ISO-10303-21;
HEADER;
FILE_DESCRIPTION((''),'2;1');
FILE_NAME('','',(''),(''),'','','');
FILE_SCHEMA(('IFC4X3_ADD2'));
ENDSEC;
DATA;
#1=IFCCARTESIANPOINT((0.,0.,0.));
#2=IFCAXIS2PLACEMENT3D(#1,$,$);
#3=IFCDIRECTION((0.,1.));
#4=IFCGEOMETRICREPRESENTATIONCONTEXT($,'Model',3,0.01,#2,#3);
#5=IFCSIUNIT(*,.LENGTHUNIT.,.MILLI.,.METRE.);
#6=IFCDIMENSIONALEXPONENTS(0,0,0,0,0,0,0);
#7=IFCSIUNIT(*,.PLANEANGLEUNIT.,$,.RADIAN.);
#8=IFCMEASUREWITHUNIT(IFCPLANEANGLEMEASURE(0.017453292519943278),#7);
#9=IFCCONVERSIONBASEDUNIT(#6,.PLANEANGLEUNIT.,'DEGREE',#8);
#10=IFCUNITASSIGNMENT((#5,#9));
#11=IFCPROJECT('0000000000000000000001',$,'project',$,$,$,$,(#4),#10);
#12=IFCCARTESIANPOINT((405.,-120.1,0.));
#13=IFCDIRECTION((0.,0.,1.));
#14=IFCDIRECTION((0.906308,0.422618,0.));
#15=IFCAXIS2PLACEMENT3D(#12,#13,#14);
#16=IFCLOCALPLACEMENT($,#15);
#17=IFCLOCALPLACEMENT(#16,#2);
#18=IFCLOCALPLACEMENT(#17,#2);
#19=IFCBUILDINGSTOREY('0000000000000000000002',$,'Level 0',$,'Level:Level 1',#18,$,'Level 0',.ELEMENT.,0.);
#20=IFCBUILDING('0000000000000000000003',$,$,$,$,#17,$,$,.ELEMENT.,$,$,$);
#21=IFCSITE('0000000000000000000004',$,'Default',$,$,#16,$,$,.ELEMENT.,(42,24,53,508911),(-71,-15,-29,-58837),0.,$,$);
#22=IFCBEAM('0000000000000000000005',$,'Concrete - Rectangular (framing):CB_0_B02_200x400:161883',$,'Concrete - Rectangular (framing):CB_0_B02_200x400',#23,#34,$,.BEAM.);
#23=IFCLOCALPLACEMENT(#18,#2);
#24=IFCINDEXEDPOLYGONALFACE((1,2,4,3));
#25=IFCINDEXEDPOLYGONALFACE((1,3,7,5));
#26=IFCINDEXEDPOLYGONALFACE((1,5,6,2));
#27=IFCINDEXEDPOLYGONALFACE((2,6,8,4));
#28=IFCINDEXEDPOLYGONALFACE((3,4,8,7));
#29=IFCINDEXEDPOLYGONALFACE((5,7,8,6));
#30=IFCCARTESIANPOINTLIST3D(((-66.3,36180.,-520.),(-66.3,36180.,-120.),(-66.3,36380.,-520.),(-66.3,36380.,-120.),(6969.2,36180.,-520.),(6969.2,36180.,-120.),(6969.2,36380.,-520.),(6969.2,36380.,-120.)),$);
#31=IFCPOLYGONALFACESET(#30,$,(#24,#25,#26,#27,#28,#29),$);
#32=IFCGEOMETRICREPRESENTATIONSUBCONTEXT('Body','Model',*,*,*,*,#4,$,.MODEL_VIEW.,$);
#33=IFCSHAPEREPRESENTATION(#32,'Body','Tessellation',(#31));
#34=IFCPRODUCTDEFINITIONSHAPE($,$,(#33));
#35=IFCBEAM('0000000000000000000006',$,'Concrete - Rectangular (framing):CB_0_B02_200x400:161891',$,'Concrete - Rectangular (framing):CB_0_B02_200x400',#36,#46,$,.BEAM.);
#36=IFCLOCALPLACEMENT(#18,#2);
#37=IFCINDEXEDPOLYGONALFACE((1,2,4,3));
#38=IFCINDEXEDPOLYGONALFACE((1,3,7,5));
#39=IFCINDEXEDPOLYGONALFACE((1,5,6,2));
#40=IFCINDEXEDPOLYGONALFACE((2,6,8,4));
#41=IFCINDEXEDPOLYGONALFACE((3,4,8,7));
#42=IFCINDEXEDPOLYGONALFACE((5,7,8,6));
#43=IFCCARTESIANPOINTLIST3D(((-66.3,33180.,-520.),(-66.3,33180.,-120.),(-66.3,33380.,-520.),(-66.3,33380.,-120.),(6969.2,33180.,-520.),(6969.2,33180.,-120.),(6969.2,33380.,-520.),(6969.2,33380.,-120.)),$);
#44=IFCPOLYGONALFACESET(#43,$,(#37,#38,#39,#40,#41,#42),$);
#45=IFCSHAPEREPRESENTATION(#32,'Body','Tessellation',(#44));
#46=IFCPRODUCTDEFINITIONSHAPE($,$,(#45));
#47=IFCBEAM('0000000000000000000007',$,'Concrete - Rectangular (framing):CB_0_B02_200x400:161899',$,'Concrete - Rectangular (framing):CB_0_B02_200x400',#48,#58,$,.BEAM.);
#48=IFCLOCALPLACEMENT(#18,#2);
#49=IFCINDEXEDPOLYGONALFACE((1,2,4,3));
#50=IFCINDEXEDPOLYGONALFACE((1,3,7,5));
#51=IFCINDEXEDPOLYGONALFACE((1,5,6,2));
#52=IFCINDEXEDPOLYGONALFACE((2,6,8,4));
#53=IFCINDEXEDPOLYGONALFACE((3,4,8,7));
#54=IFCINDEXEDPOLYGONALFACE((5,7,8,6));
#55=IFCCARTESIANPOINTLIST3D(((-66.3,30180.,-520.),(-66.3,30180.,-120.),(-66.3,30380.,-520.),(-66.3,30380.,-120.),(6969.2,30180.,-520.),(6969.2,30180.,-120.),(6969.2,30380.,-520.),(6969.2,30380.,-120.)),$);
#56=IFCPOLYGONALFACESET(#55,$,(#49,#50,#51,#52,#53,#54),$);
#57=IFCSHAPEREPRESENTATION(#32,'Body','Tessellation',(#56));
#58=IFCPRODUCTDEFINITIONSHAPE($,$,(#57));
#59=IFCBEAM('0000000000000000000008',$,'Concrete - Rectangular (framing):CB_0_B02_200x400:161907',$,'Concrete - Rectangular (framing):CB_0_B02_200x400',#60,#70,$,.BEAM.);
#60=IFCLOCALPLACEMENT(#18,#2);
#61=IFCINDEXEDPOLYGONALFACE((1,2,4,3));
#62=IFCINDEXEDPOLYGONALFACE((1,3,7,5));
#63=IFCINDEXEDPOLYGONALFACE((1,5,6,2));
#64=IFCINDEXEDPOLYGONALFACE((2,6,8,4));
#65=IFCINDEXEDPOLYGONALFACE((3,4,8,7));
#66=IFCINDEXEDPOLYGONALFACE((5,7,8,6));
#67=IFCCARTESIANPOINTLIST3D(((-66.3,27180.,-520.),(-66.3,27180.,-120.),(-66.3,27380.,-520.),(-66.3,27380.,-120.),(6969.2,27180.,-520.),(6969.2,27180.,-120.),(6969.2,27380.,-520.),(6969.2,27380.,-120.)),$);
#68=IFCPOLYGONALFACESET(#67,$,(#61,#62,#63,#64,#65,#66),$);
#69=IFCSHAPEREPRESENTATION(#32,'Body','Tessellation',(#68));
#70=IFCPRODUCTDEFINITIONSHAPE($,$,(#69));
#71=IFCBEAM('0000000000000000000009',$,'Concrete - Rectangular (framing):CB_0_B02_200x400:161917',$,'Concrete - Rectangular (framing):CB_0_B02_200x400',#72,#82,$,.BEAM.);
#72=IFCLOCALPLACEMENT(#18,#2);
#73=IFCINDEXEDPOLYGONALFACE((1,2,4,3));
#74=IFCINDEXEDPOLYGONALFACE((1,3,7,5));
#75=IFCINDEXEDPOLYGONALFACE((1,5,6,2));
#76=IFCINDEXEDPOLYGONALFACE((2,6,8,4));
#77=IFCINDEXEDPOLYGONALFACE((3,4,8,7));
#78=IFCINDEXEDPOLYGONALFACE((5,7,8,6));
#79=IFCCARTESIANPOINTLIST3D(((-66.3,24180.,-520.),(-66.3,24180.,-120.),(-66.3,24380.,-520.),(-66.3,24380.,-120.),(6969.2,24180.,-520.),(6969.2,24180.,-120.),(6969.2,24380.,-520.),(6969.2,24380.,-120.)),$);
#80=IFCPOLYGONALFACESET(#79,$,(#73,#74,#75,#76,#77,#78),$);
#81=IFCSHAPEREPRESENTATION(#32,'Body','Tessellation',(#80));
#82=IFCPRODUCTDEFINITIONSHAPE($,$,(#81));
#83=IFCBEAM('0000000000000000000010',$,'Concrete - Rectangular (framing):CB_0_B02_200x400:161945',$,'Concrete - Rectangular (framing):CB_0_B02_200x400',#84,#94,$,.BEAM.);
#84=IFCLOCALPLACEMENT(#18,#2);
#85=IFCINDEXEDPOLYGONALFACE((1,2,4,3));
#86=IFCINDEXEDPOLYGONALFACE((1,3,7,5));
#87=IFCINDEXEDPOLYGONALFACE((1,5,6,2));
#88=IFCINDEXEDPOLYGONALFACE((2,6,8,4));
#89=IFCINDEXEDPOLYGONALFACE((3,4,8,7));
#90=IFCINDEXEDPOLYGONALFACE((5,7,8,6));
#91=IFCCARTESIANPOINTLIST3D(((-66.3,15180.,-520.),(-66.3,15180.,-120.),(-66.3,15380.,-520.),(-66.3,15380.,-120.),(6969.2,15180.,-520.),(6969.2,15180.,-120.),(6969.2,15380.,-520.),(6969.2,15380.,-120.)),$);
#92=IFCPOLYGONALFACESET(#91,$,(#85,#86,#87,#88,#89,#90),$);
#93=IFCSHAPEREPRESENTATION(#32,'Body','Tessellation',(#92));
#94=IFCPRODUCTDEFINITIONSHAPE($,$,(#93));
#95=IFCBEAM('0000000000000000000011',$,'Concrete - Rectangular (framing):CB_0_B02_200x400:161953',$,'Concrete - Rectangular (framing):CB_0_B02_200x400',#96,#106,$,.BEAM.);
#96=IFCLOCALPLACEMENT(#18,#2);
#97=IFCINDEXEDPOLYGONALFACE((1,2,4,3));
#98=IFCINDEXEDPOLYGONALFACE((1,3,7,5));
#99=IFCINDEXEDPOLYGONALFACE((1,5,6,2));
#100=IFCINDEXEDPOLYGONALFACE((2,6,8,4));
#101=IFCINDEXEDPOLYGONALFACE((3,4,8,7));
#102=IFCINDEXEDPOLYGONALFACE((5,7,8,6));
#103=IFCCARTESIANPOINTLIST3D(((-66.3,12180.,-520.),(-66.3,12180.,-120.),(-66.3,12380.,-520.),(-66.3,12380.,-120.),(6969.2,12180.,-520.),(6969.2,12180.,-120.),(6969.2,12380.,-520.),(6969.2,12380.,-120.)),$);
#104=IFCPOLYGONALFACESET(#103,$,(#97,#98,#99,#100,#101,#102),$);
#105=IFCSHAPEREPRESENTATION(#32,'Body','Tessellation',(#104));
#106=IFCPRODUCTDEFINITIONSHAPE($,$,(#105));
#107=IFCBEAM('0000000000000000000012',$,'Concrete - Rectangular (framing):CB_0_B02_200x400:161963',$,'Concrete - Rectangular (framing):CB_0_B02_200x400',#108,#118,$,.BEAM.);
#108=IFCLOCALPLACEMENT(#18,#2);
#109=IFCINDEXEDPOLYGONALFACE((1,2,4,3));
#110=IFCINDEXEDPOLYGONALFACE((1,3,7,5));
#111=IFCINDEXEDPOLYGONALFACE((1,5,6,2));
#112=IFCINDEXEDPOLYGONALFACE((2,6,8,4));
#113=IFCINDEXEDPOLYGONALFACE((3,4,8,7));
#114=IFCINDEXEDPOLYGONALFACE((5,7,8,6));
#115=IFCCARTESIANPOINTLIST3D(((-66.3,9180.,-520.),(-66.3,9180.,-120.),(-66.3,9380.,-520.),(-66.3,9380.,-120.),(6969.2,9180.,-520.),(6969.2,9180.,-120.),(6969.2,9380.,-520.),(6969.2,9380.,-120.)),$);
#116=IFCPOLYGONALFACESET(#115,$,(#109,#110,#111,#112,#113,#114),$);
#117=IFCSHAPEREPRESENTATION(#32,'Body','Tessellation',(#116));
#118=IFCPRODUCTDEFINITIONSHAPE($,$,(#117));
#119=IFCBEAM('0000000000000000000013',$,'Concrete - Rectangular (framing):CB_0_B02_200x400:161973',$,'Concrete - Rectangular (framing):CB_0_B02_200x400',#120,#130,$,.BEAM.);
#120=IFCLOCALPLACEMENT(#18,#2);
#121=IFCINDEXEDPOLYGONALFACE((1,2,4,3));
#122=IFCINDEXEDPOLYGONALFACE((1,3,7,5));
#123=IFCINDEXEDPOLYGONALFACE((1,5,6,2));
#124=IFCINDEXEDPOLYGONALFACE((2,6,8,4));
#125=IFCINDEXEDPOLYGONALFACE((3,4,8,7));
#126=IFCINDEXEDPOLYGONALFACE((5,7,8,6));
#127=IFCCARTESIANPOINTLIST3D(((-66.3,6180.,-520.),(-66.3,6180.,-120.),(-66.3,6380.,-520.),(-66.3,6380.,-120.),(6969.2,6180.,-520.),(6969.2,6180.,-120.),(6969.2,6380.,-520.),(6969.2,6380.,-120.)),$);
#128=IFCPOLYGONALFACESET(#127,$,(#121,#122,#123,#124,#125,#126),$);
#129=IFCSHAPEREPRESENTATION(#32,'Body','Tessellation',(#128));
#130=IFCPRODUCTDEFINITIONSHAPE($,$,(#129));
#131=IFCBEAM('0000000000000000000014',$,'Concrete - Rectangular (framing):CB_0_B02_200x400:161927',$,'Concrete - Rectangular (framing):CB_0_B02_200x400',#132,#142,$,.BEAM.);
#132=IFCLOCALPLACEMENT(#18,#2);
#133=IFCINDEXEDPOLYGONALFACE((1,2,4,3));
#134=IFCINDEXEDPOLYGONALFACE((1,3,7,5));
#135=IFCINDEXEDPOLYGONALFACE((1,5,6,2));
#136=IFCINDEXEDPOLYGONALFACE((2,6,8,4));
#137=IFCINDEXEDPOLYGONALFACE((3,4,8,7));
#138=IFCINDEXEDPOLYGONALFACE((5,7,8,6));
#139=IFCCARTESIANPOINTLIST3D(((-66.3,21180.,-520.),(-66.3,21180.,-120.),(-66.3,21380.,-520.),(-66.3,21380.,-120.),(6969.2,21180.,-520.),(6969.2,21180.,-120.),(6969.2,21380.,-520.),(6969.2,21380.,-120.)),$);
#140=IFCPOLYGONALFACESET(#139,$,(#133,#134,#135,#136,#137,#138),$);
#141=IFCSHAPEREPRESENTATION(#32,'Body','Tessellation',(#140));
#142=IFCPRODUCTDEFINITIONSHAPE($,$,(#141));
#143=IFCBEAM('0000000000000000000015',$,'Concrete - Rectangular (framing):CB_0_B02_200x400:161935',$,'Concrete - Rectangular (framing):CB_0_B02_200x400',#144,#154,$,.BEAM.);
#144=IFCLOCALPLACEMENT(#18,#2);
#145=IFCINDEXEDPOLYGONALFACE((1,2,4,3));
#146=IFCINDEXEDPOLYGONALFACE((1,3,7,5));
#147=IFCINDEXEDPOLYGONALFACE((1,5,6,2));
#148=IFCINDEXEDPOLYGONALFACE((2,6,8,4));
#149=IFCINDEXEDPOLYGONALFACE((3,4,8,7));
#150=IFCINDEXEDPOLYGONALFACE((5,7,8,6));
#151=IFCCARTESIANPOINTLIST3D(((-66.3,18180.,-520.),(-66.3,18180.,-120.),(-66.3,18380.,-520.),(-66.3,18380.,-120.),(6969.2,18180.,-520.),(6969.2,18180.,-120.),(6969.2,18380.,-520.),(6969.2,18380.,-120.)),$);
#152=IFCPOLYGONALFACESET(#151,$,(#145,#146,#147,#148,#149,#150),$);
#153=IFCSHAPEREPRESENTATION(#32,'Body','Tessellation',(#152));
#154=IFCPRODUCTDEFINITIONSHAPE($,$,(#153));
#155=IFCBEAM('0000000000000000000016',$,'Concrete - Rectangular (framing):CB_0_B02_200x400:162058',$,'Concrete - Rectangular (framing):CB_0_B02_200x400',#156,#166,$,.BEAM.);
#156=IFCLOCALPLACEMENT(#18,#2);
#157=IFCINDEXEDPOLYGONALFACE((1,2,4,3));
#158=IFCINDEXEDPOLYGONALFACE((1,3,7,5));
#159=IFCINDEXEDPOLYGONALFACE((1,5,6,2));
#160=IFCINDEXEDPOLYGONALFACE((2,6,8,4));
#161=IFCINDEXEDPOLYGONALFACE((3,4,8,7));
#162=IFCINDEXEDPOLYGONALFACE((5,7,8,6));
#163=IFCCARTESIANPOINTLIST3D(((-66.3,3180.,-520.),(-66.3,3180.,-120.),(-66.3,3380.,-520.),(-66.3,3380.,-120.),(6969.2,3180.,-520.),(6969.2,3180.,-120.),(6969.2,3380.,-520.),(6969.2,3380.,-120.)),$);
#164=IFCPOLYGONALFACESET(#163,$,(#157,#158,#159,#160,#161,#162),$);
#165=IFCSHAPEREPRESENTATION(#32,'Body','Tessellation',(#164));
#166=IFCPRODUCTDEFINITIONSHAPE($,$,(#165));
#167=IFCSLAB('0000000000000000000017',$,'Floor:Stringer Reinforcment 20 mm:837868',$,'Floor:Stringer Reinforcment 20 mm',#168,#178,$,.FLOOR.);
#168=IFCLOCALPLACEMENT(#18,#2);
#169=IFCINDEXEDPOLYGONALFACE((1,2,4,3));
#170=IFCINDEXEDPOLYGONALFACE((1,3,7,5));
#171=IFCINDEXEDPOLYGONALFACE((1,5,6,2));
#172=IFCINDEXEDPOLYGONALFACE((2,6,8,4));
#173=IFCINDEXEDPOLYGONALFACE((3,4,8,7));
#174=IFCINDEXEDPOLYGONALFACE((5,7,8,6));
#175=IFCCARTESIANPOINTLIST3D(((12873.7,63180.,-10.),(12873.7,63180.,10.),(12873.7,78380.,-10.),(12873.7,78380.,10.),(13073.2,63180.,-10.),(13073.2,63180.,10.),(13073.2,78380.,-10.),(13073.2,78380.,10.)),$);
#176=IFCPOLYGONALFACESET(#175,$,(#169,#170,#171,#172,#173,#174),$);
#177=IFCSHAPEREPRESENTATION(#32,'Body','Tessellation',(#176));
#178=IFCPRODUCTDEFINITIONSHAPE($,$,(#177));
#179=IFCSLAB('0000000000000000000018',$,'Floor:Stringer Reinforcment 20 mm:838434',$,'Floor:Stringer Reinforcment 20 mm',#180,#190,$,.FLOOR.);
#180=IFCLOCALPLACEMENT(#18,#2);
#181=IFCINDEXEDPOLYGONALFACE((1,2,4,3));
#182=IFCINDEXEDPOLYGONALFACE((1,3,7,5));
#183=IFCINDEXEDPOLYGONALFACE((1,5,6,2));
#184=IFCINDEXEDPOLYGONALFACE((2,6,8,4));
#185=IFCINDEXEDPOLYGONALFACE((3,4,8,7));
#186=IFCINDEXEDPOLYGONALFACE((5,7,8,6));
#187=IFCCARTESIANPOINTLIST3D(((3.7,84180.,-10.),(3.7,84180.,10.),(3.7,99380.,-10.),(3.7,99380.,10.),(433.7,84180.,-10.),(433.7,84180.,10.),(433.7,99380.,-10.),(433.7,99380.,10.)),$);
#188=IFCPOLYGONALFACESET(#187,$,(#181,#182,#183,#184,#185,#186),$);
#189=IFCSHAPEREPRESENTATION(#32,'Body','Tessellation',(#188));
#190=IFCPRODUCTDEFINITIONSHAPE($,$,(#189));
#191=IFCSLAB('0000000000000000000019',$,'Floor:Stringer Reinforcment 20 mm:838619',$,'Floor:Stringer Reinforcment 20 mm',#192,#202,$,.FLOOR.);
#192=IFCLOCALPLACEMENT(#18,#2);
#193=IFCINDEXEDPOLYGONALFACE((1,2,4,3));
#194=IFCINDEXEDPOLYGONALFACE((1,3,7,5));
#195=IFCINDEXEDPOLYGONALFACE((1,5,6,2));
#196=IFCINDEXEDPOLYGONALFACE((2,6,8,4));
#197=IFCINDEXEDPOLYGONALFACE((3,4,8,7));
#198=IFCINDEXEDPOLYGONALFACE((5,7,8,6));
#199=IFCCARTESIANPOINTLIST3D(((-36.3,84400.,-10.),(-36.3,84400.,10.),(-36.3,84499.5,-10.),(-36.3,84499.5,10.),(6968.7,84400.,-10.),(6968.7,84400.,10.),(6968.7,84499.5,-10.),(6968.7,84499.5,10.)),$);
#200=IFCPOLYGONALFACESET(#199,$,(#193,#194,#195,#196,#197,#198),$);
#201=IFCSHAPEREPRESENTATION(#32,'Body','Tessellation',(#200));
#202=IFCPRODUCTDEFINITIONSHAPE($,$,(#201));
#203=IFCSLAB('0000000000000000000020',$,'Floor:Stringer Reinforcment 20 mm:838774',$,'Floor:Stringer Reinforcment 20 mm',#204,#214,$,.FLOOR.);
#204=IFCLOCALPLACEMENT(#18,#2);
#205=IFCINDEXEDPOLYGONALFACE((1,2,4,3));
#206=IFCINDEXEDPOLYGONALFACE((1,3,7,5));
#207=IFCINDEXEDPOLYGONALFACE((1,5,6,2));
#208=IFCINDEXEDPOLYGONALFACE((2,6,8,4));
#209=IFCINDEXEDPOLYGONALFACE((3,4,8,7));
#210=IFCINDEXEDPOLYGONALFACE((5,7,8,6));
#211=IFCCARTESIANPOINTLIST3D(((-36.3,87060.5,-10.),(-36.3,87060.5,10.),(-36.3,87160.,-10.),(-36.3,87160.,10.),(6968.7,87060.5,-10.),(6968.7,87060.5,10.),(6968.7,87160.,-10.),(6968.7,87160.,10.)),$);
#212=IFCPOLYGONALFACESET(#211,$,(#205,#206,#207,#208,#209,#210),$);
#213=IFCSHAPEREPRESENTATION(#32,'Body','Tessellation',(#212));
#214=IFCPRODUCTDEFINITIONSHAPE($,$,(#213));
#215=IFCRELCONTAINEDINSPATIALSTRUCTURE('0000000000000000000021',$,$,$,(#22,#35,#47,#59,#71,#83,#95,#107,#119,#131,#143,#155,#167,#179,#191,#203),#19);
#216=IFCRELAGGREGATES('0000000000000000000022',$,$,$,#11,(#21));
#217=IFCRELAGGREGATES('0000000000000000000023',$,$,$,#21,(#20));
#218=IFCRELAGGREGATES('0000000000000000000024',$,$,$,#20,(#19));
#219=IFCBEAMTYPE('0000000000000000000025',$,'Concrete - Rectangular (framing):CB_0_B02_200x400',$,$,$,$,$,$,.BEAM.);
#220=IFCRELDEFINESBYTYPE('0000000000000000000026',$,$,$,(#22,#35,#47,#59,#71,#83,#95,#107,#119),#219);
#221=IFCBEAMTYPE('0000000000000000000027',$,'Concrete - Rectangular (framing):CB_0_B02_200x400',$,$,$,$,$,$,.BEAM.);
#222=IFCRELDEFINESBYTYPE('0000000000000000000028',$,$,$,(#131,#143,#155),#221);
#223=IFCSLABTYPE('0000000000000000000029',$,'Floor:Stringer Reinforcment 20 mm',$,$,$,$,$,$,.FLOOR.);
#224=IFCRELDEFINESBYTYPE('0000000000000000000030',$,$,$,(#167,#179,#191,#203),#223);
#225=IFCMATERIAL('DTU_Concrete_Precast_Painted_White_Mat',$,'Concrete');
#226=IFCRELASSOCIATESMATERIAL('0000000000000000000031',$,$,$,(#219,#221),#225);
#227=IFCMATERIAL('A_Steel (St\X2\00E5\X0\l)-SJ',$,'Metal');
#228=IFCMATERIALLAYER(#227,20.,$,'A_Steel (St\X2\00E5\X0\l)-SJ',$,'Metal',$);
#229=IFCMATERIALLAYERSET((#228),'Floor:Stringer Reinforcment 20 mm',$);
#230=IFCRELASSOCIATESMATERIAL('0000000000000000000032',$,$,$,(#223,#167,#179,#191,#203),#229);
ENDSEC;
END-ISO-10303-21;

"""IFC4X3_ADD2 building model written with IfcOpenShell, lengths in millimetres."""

from ifc_helpers import new_model, entity, si_unit, converted_unit, direction, frame, frame_2d, origin, origin_2d_with_axis, place, context, subcontext, project, spatial, rectangle, extrude, source, transform, mapped, material, layer, layer_set, layer_usage, material_profile, profile_set, type_object, type_shapes, element, save


model = new_model("IFC4X3_ADD2")

# Units and contexts
model_context = context("Model", 3, precision=0.01, world=origin(), true_north=direction((0.0, 1.0)))
body_context = subcontext(model_context, "Body", "Model", "MODEL_VIEW")
ifc_project = project(units=[si_unit("LENGTHUNIT", "METRE", prefix="MILLI"), converted_unit("PLANEANGLEUNIT", "DEGREE", entity("IfcPlaneAngleMeasure", 0.017453292519943278), si_unit("PLANEANGLEUNIT", "RADIAN"), dimensions=[0, 0, 0, 0, 0, 0, 0])], contexts=[model_context])

# Site, building, storey
site_placement = place(None, frame((405.0, -120.1, 0.0), z_axis=(0.0, 0.0, 1.0), x_axis=(0.906308, 0.422618, 0.0)))
site = spatial("IfcSite", under=ifc_project, at=site_placement, Name="Default", CompositionType="ELEMENT", RefLatitude=(42, 24, 53, 508911), RefLongitude=(-71, -15, -29, -58837), RefElevation=0.0)
building_placement = place(site_placement, origin())
building = spatial("IfcBuilding", under=site, at=building_placement, CompositionType="ELEMENT")
storey_placement = place(building_placement, origin())
storey = spatial("IfcBuildingStorey", under=building, at=storey_placement, Name="Level 0", ObjectType="Level:Level 1", LongName="Level 0", CompositionType="ELEMENT", Elevation=0.0)

# Beams
ifc_material_1 = material(Name="DTU_Concrete_Precast_Painted_White_Mat", Category="Concrete")
ifc_material_profile_1 = material_profile(ifc_material_1, rectangle(XDim=7035.5, YDim=200.0, at=frame_2d((0.0, 0.0), x_axis=(1.0, 0.0))), Name="CB_0_B02_200x400")
ifc_profile_set_1 = profile_set([ifc_material_profile_1], Name="CB_0_B02_200x400")
beam_type_1 = type_object("IfcBeamType", Name="Concrete - Rectangular (framing):CB_0_B02_200x400", PredefinedType="BEAM", material=ifc_profile_set_1)
shared_shape_1 = source(origin(), body_context, "Body", "SweptSolid", [
    extrude(rectangle(XDim=7035.5, YDim=200.0, at=frame_2d((0.0, 0.0), x_axis=(1.0, 0.0))), frame((-45.2, 0.0, -200.0), z_axis=(0.0, 0.0, 1.0), x_axis=(-1.0, 0.0, 0.0)), (0.0, 0.0, 1.0), 400.0),
])
type_shapes(beam_type_1, [shared_shape_1])
for number, where, z_axis, x_axis, name in (
    (1, (3406.2, 36280.0, -320.0), (0.0, 0.0, 1.0), (-1.0, 0.0, 0.0), "Concrete - Rectangular (framing):CB_0_B02_200x400:161883"),
    (2, (3406.2, 33280.0, -320.0), (0.0, 0.0, 1.0), (-1.0, 0.0, 0.0), "Concrete - Rectangular (framing):CB_0_B02_200x400:161891"),
    (3, (3406.2, 30280.0, -320.0), (0.0, 0.0, 1.0), (-1.0, 0.0, 0.0), "Concrete - Rectangular (framing):CB_0_B02_200x400:161899"),
    (4, (3406.2, 27280.0, -320.0), (0.0, 0.0, 1.0), (-1.0, 0.0, 0.0), "Concrete - Rectangular (framing):CB_0_B02_200x400:161907"),
    (5, (3406.2, 24280.0, -320.0), (0.0, 0.0, 1.0), (-1.0, 0.0, 0.0), "Concrete - Rectangular (framing):CB_0_B02_200x400:161917"),
    (6, (3406.2, 15280.0, -320.0), (0.0, 0.0, 1.0), (-1.0, 0.0, 0.0), "Concrete - Rectangular (framing):CB_0_B02_200x400:161945"),
    (7, (3406.2, 12280.0, -320.0), (0.0, 0.0, 1.0), (-1.0, 0.0, 0.0), "Concrete - Rectangular (framing):CB_0_B02_200x400:161953"),
    (8, (3406.2, 9280.0, -320.0), (0.0, 0.0, 1.0), (-1.0, 0.0, 0.0), "Concrete - Rectangular (framing):CB_0_B02_200x400:161963"),
    (9, (3406.2, 6280.0, -320.0), (0.0, 0.0, 1.0), (-1.0, 0.0, 0.0), "Concrete - Rectangular (framing):CB_0_B02_200x400:161973"),
):
    element("IfcBeam", number, at=place(storey_placement, frame(where, z_axis=z_axis, x_axis=x_axis)), inside=storey, type_object=beam_type_1, Name=name, ObjectType="Concrete - Rectangular (framing):CB_0_B02_200x400", PredefinedType="BEAM", context=body_context, shape_type="MappedRepresentation", body=[
        mapped(shared_shape_1, transform((0.0, 0.0, 0.0), scale=1.0)),
    ])
beam_type_2 = type_object("IfcBeamType", Name="Concrete - Rectangular (framing):CB_0_B02_200x400", PredefinedType="BEAM", material=ifc_profile_set_1)
shared_shape_2 = source(origin(), body_context, "Body", "SweptSolid", [
    extrude(rectangle(XDim=7035.5, YDim=200.0, at=origin_2d_with_axis()), frame((-45.3, 0.0, -200.0), z_axis=(0.0, 0.0, 1.0), x_axis=(-1.0, 0.0, 0.0)), (0.0, 0.0, 1.0), 400.0),
])
type_shapes(beam_type_2, [shared_shape_2])
for number, where, z_axis, x_axis, name in (
    (10, (3406.2, 21280.0, -320.0), (0.0, 0.0, 1.0), (-1.0, 0.0, 0.0), "Concrete - Rectangular (framing):CB_0_B02_200x400:161927"),
    (11, (3406.2, 18280.0, -320.0), (0.0, 0.0, 1.0), (-1.0, 0.0, 0.0), "Concrete - Rectangular (framing):CB_0_B02_200x400:161935"),
    (12, (3406.2, 3280.0, -320.0), (0.0, 0.0, 1.0), (-1.0, 0.0, 0.0), "Concrete - Rectangular (framing):CB_0_B02_200x400:162058"),
):
    element("IfcBeam", number, at=place(storey_placement, frame(where, z_axis=z_axis, x_axis=x_axis)), inside=storey, type_object=beam_type_2, Name=name, ObjectType="Concrete - Rectangular (framing):CB_0_B02_200x400", PredefinedType="BEAM", context=body_context, shape_type="MappedRepresentation", body=[
        mapped(shared_shape_2, transform((0.0, 0.0, 0.0), scale=1.0)),
    ])

# Slabs
ifc_material_2 = material(Name="A_Steel (Stål)-SJ", Category="Metal")
ifc_layer_1 = layer(ifc_material_2, 20.0, Name="A_Steel (Stål)-SJ", Category="Metal")
ifc_layer_set_1 = layer_set([ifc_layer_1], Name="Floor:Stringer Reinforcment 20 mm")
ifc_layer_usage_1 = layer_usage(ifc_layer_set_1, "AXIS3", "POSITIVE", 0.0)
slab_type_1 = type_object("IfcSlabType", Name="Floor:Stringer Reinforcment 20 mm", PredefinedType="FLOOR", material=ifc_layer_set_1)
slab_1_placement = place(storey_placement, origin())
element("IfcSlab", 13, at=slab_1_placement, inside=storey, type_object=slab_type_1, material=ifc_layer_usage_1, Name="Floor:Stringer Reinforcment 20 mm:837868", ObjectType="Floor:Stringer Reinforcment 20 mm", PredefinedType="FLOOR", context=body_context, shape_type="SweptSolid", body=[
    extrude(rectangle(XDim=15200.0, YDim=199.5, at=frame_2d((0.0, 0.0), x_axis=(1.0, 0.0))), frame((12973.5, 70780.0, 10.0), z_axis=(0.0, 0.0, -1.0), x_axis=(0.0, 1.0, 0.0)), (0.0, 0.0, 1.0), 20.0),
])
ifc_layer_usage_2 = layer_usage(ifc_layer_set_1, "AXIS3", "POSITIVE", 0.0)
slab_2_placement = place(storey_placement, origin())
element("IfcSlab", 14, at=slab_2_placement, inside=storey, type_object=slab_type_1, material=ifc_layer_usage_2, Name="Floor:Stringer Reinforcment 20 mm:838434", ObjectType="Floor:Stringer Reinforcment 20 mm", PredefinedType="FLOOR", context=body_context, shape_type="SweptSolid", body=[
    extrude(rectangle(XDim=15200.0, YDim=430.0, at=origin_2d_with_axis()), frame((218.7, 91780.0, 10.0), z_axis=(0.0, 0.0, -1.0), x_axis=(0.0, 1.0, 0.0)), (0.0, 0.0, 1.0), 20.0),
])
ifc_layer_usage_3 = layer_usage(ifc_layer_set_1, "AXIS3", "POSITIVE", 0.0)
slab_3_placement = place(storey_placement, origin())
element("IfcSlab", 15, at=slab_3_placement, inside=storey, type_object=slab_type_1, material=ifc_layer_usage_3, Name="Floor:Stringer Reinforcment 20 mm:838619", ObjectType="Floor:Stringer Reinforcment 20 mm", PredefinedType="FLOOR", context=body_context, shape_type="SweptSolid", body=[
    extrude(rectangle(XDim=99.5, YDim=7005.0, at=origin_2d_with_axis()), frame((3466.2, 84449.8, 10.0), z_axis=(0.0, 0.0, -1.0), x_axis=(0.0, 1.0, 0.0)), (0.0, 0.0, 1.0), 20.0),
])
ifc_layer_usage_4 = layer_usage(ifc_layer_set_1, "AXIS3", "POSITIVE", 0.0)
slab_4_placement = place(storey_placement, origin())
element("IfcSlab", 16, at=slab_4_placement, inside=storey, type_object=slab_type_1, material=ifc_layer_usage_4, Name="Floor:Stringer Reinforcment 20 mm:838774", ObjectType="Floor:Stringer Reinforcment 20 mm", PredefinedType="FLOOR", context=body_context, shape_type="SweptSolid", body=[
    extrude(rectangle(XDim=99.5, YDim=7005.0, at=frame_2d((0.0, 0.0), x_axis=(1.0, 0.0))), frame((3466.2, 87110.2, 10.0), z_axis=(0.0, 0.0, -1.0), x_axis=(0.0, 1.0, 0.0)), (0.0, 0.0, 1.0), 20.0),
])

save(model, "model.ifc")
